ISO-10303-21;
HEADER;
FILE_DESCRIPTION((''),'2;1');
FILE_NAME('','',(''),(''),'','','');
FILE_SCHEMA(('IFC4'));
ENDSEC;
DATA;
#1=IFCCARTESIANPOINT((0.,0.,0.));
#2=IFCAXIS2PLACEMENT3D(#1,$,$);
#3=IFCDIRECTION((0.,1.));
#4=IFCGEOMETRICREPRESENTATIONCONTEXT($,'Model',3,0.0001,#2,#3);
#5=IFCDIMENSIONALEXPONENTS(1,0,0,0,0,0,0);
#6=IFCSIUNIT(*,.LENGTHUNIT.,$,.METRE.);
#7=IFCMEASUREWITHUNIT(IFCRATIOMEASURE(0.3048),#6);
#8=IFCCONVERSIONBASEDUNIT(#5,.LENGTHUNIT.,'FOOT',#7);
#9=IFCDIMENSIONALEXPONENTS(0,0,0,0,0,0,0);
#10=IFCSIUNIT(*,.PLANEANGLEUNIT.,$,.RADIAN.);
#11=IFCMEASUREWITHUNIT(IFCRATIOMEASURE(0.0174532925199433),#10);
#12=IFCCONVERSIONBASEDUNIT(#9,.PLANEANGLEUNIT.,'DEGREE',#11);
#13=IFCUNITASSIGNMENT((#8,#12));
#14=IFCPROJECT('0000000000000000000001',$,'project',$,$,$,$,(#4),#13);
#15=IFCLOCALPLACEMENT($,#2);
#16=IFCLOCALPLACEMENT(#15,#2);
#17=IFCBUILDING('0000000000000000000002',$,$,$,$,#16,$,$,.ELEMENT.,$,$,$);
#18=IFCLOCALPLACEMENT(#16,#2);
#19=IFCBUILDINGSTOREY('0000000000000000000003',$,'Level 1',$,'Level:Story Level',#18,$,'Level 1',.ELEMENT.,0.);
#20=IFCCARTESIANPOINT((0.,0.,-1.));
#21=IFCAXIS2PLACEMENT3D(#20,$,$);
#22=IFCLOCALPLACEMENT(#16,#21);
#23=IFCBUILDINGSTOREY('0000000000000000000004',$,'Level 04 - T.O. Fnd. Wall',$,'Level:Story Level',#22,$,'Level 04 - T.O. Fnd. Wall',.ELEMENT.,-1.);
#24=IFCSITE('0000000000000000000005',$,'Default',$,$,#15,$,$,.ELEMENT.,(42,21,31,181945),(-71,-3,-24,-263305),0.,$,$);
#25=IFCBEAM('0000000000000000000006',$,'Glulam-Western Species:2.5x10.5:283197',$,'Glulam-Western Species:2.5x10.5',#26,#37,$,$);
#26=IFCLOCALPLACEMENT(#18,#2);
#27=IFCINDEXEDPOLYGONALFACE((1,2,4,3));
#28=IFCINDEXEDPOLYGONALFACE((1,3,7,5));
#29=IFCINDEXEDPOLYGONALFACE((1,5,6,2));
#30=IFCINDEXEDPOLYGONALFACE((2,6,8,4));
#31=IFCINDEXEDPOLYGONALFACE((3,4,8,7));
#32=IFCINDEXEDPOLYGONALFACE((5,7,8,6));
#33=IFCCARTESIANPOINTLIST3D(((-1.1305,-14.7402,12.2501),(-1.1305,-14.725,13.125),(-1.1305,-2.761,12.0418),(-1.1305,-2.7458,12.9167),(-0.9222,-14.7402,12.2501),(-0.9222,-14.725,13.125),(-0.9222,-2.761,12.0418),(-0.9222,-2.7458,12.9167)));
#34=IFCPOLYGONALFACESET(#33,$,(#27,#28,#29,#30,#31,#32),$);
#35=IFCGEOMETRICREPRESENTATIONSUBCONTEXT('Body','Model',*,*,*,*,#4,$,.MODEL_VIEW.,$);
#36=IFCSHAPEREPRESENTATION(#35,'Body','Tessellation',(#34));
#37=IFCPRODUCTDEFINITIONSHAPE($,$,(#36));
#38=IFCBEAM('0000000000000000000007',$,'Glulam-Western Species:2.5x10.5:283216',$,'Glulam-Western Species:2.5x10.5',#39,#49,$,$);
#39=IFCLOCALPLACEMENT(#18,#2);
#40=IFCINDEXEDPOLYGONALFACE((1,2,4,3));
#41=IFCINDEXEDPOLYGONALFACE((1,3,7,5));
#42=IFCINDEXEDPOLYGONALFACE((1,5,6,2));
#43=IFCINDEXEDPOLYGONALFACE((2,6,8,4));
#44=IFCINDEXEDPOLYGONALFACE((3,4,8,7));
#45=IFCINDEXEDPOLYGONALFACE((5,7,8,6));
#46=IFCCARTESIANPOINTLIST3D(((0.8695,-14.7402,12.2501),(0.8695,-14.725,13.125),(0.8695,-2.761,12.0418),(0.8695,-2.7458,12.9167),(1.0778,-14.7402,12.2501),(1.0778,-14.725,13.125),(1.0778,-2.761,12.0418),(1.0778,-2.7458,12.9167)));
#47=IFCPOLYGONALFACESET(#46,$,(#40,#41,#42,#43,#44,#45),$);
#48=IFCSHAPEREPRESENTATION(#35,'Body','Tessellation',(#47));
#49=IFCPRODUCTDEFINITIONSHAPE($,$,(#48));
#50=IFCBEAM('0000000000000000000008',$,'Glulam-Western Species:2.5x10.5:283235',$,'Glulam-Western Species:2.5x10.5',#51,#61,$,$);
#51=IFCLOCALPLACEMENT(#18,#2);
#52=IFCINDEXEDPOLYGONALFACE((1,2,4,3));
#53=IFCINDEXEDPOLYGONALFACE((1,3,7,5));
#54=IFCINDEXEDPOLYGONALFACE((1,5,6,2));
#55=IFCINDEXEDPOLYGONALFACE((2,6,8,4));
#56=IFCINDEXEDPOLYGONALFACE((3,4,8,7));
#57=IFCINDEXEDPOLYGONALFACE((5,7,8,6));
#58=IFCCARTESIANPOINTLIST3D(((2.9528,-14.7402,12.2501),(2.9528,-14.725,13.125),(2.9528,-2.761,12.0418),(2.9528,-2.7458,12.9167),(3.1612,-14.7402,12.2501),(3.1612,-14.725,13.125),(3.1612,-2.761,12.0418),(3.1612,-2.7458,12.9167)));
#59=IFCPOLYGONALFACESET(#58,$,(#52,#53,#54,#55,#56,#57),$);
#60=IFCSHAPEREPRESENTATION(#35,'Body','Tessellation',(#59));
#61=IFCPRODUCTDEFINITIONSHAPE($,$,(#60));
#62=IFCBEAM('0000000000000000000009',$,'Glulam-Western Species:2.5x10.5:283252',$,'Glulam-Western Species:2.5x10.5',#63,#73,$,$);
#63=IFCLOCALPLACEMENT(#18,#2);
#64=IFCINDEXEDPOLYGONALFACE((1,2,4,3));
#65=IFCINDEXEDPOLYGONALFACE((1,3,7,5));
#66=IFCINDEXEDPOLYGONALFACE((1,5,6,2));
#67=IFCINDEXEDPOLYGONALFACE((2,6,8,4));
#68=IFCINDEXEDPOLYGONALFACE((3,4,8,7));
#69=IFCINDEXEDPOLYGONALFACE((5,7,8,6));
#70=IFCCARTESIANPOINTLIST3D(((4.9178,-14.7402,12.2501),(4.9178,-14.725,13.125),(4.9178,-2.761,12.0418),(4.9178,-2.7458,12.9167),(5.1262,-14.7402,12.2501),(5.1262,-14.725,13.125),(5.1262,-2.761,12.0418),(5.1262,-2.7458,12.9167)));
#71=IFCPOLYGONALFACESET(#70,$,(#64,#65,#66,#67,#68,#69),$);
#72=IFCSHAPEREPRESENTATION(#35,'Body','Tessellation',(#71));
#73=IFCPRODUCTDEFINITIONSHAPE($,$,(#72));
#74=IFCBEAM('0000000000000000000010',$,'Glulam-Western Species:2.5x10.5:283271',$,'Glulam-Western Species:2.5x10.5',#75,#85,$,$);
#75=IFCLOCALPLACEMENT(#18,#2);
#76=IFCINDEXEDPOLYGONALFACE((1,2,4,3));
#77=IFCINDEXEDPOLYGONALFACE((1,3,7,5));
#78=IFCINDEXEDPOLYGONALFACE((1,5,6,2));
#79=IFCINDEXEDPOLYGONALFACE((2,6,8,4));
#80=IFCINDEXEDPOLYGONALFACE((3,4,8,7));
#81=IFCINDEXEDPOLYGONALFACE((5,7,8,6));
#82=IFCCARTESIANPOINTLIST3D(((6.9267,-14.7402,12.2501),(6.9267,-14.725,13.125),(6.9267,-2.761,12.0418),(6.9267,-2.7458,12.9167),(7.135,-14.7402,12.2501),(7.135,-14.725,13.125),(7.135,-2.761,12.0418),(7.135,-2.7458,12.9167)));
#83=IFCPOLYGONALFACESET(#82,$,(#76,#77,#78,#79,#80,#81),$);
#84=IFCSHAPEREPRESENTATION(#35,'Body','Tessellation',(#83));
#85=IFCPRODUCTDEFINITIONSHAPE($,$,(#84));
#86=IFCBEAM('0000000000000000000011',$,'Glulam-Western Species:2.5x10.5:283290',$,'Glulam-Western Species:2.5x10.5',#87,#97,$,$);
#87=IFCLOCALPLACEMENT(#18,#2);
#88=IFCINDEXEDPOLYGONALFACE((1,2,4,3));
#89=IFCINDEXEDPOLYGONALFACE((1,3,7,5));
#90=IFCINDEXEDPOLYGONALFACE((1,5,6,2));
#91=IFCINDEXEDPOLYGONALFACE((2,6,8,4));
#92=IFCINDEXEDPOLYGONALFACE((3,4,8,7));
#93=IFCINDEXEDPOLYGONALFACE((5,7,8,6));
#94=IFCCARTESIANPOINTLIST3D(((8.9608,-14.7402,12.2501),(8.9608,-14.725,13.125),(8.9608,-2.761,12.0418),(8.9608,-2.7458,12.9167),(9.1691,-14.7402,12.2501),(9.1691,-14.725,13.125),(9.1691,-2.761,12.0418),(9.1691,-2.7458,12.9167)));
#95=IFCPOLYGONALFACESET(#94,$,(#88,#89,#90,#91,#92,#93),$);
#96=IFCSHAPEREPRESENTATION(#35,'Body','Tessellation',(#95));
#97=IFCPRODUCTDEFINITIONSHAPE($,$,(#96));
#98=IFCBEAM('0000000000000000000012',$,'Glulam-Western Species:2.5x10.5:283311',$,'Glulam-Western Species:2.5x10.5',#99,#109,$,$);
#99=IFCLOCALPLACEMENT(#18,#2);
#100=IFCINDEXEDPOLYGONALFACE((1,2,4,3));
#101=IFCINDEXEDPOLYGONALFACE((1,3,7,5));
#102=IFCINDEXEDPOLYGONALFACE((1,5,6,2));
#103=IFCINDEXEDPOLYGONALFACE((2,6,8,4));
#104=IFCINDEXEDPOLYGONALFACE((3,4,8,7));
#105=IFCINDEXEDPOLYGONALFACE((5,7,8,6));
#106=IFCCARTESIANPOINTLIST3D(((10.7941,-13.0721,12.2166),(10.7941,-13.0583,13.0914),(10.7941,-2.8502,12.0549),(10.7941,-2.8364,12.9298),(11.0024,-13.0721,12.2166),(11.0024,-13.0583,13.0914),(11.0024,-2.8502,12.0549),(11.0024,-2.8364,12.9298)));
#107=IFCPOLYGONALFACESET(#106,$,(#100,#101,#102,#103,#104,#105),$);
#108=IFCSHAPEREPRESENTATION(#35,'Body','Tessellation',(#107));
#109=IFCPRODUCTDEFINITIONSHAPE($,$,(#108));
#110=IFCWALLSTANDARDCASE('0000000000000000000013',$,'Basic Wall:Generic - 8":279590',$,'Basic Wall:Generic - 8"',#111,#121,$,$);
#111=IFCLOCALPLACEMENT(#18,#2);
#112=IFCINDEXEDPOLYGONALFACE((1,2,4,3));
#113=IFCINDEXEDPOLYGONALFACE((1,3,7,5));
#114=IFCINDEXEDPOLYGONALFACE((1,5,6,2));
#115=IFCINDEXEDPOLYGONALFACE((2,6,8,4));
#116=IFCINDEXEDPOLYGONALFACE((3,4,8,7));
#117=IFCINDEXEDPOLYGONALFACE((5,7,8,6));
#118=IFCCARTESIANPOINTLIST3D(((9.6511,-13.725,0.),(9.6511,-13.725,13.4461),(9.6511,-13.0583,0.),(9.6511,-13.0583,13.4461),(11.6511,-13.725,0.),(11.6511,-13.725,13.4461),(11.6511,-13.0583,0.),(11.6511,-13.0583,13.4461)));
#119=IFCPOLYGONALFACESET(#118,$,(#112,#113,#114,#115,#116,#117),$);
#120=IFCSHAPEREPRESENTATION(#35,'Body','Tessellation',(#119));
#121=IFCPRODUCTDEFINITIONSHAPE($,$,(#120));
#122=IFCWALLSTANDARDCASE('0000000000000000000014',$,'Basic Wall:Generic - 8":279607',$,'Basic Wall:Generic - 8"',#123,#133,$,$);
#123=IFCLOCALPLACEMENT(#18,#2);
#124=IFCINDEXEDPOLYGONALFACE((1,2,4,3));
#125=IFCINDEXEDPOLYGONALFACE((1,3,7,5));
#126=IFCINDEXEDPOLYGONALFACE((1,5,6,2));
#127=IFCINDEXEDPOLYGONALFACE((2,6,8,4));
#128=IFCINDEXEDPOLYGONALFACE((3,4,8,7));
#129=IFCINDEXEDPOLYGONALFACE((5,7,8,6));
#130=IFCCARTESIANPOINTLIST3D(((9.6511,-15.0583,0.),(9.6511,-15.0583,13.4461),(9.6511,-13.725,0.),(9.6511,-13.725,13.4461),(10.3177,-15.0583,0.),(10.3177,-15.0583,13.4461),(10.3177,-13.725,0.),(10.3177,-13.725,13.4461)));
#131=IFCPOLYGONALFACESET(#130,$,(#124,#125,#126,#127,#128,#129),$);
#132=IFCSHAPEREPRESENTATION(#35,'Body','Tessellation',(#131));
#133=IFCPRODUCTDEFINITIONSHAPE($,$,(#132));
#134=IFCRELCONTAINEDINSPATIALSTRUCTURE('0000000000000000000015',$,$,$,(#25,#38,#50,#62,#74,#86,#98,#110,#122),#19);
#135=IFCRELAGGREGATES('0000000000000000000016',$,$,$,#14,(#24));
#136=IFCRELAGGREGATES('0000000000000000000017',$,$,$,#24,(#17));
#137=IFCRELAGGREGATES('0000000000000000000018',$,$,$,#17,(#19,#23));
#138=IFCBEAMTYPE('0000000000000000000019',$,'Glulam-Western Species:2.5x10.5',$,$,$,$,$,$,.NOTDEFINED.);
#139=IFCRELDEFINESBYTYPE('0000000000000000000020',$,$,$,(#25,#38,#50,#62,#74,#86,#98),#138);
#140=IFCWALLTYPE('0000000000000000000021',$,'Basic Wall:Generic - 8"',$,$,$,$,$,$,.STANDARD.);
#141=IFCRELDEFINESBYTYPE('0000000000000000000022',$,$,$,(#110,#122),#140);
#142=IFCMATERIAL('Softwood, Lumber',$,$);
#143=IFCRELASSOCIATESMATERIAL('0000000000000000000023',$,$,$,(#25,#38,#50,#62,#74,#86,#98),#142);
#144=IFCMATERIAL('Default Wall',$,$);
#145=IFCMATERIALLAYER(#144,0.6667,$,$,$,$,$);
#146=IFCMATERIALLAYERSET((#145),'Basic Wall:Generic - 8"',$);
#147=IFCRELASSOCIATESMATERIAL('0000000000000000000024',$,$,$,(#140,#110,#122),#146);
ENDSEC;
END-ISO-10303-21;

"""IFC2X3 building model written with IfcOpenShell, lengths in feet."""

from ifc_helpers import new_model, entity, si_unit, converted_unit, direction, frame, frame_2d, origin, origin_2d_with_axis, place, context, subcontext, project, spatial, rectangle, extrude, material, layer, layer_set, layer_usage, type_object, element, save


model = new_model("IFC2X3")

# Units and contexts
model_context = context("Model", 3, precision=0.0001, world=origin(), true_north=direction((0.0, 1.0)))
body_context = subcontext(model_context, "Body", "Model", "MODEL_VIEW")
ifc_project = project(units=[converted_unit("LENGTHUNIT", "FOOT", entity("IfcRatioMeasure", 0.3048), si_unit("LENGTHUNIT", "METRE"), dimensions=[1, 0, 0, 0, 0, 0, 0]), converted_unit("PLANEANGLEUNIT", "DEGREE", entity("IfcRatioMeasure", 0.0174532925199433), si_unit("PLANEANGLEUNIT", "RADIAN"), dimensions=[0, 0, 0, 0, 0, 0, 0])], contexts=[model_context])

# Site, building, storey
site_placement = place(None, origin())
site = spatial("IfcSite", under=ifc_project, at=site_placement, Name="Default", CompositionType="ELEMENT", RefLatitude=(42, 21, 31, 181945), RefLongitude=(-71, -3, -24, -263305), RefElevation=0.0)
building_placement = place(site_placement, origin())
building = spatial("IfcBuilding", under=site, at=building_placement, CompositionType="ELEMENT")
storey_1_placement = place(building_placement, origin())
storey_1 = spatial("IfcBuildingStorey", under=building, at=storey_1_placement, Name="Level 1", ObjectType="Level:Story Level", LongName="Level 1", CompositionType="ELEMENT", Elevation=0.0)

# Beams
ifc_material_1 = material(Name="Softwood, Lumber")
beam_type = type_object("IfcBeamType", Name="Glulam-Western Species:2.5x10.5", PredefinedType="NOTDEFINED")
for number, where, z_axis, x_axis, name in (
    (1, (-1.0263, -2.7458, 12.9167), (0.0, 0.017389, 0.999849), (0.0, -0.999849, 0.017389), "Glulam-Western Species:2.5x10.5:283197"),
    (2, (0.9737, -2.7458, 12.9167), (0.0, 0.017389, 0.999849), (0.0, -0.999849, 0.017389), "Glulam-Western Species:2.5x10.5:283216"),
):
    element("IfcBeam", number, at=place(storey_1_placement, frame(where, z_axis=z_axis, x_axis=x_axis)), inside=storey_1, type_object=beam_type, material=ifc_material_1, Name=name, ObjectType="Glulam-Western Species:2.5x10.5", context=body_context, shape_type="SweptSolid", body=[
        extrude(rectangle(XDim=0.875, YDim=0.2083, at=frame_2d((0.0, 0.0), x_axis=(1.0, 0.0))), frame((0.0, 0.0, -0.4375), z_axis=(1.0, 0.0, 0.0), x_axis=(0.0, 0.0, -1.0)), (0.0, 0.0, 1.0), 11.981),
    ])
beam_1_placement = place(storey_1_placement, frame((3.057, -2.7458, 12.9167), z_axis=(0.0, 0.017389, 0.999849), x_axis=(0.0, -0.999849, 0.017389)))
element("IfcBeam", 3, at=beam_1_placement, inside=storey_1, type_object=beam_type, material=ifc_material_1, Name="Glulam-Western Species:2.5x10.5:283235", ObjectType="Glulam-Western Species:2.5x10.5", context=body_context, shape_type="SweptSolid", body=[
    extrude(rectangle(XDim=0.875, YDim=0.2083, at=origin_2d_with_axis()), frame((0.0, 0.0, -0.4375), z_axis=(1.0, 0.0, 0.0), x_axis=(0.0, 0.0, -1.0)), (0.0, 0.0, 1.0), 11.981),
])
for number, where, z_axis, x_axis, name in (
    (4, (5.022, -2.7458, 12.9167), (0.0, 0.017389, 0.999849), (0.0, -0.999849, 0.017389), "Glulam-Western Species:2.5x10.5:283252"),
    (5, (7.0309, -2.7458, 12.9167), (0.0, 0.017389, 0.999849), (0.0, -0.999849, 0.017389), "Glulam-Western Species:2.5x10.5:283271"),
    (6, (9.0649, -2.7458, 12.9167), (0.0, 0.017389, 0.999849), (0.0, -0.999849, 0.017389), "Glulam-Western Species:2.5x10.5:283290"),
):
    element("IfcBeam", number, at=place(storey_1_placement, frame(where, z_axis=z_axis, x_axis=x_axis)), inside=storey_1, type_object=beam_type, material=ifc_material_1, Name=name, ObjectType="Glulam-Western Species:2.5x10.5", context=body_context, shape_type="SweptSolid", body=[
        extrude(rectangle(XDim=0.875, YDim=0.2083, at=origin_2d_with_axis()), frame((0.0, 0.0, -0.4375), z_axis=(1.0, 0.0, 0.0), x_axis=(0.0, 0.0, -1.0)), (0.0, 0.0, 1.0), 11.981),
    ])
beam_2_placement = place(storey_1_placement, frame((10.8983, -2.7322, 12.9282), z_axis=(0.0, 0.01581, 0.999875), x_axis=(0.0, -0.999875, 0.01581)))
element("IfcBeam", 7, at=beam_2_placement, inside=storey_1, type_object=beam_type, material=ifc_material_1, Name="Glulam-Western Species:2.5x10.5:283311", ObjectType="Glulam-Western Species:2.5x10.5", context=body_context, shape_type="SweptSolid", body=[
    extrude(rectangle(XDim=0.875, YDim=0.2083, at=origin_2d_with_axis()), frame((0.1042, 0.0, -0.4375), z_axis=(1.0, 0.0, 0.0), x_axis=(0.0, 0.0, -1.0)), (0.0, 0.0, 1.0), 10.2232),
])

# Walls
ifc_material_2 = material(Name="Default Wall")
ifc_layer = layer(ifc_material_2, 0.6667)
ifc_layer_set = layer_set([ifc_layer], Name="Basic Wall:Generic - 8\"")
ifc_layer_usage_1 = layer_usage(ifc_layer_set, "AXIS2", "NEGATIVE", 0.3333)
wall_type = type_object("IfcWallType", Name="Basic Wall:Generic - 8\"", PredefinedType="STANDARD", material=ifc_layer_set)
wall_1_placement = place(storey_1_placement, frame((11.6511, -13.3916, 0.0), z_axis=(0.0, 0.0, 1.0), x_axis=(-1.0, 0.0, 0.0)))
element("IfcWallStandardCase", 8, at=wall_1_placement, inside=storey_1, type_object=wall_type, material=ifc_layer_usage_1, Name="Basic Wall:Generic - 8\":279590", ObjectType="Basic Wall:Generic - 8\"", context=body_context, shape_type="SweptSolid", body=[
    extrude(rectangle(XDim=2.0, YDim=0.6667, at=frame_2d((1.0, 0.0), x_axis=(-1.0, 0.0))), origin(), (0.0, 0.0, 1.0), 13.4461),
])
ifc_layer_usage_2 = layer_usage(ifc_layer_set, "AXIS2", "NEGATIVE", 0.3333)
wall_2_placement = place(storey_1_placement, frame((9.9844, -13.725, 0.0), z_axis=(0.0, 0.0, 1.0), x_axis=(0.0, -1.0, 0.0)))
element("IfcWallStandardCase", 9, at=wall_2_placement, inside=storey_1, type_object=wall_type, material=ifc_layer_usage_2, Name="Basic Wall:Generic - 8\":279607", ObjectType="Basic Wall:Generic - 8\"", context=body_context, shape_type="SweptSolid", body=[
    extrude(rectangle(XDim=1.3333, YDim=0.6667, at=frame_2d((0.6667, 0.0), x_axis=(-1.0, 0.0))), origin(), (0.0, 0.0, 1.0), 13.4461),
])

# Shared definitions
storey_2_placement = place(building_placement, frame((0.0, 0.0, -1.0)))
storey_2 = spatial("IfcBuildingStorey", under=building, at=storey_2_placement, Name="Level 04 - T.O. Fnd. Wall", ObjectType="Level:Story Level", LongName="Level 04 - T.O. Fnd. Wall", CompositionType="ELEMENT", Elevation=-1.0)

save(model, "model.ifc")
